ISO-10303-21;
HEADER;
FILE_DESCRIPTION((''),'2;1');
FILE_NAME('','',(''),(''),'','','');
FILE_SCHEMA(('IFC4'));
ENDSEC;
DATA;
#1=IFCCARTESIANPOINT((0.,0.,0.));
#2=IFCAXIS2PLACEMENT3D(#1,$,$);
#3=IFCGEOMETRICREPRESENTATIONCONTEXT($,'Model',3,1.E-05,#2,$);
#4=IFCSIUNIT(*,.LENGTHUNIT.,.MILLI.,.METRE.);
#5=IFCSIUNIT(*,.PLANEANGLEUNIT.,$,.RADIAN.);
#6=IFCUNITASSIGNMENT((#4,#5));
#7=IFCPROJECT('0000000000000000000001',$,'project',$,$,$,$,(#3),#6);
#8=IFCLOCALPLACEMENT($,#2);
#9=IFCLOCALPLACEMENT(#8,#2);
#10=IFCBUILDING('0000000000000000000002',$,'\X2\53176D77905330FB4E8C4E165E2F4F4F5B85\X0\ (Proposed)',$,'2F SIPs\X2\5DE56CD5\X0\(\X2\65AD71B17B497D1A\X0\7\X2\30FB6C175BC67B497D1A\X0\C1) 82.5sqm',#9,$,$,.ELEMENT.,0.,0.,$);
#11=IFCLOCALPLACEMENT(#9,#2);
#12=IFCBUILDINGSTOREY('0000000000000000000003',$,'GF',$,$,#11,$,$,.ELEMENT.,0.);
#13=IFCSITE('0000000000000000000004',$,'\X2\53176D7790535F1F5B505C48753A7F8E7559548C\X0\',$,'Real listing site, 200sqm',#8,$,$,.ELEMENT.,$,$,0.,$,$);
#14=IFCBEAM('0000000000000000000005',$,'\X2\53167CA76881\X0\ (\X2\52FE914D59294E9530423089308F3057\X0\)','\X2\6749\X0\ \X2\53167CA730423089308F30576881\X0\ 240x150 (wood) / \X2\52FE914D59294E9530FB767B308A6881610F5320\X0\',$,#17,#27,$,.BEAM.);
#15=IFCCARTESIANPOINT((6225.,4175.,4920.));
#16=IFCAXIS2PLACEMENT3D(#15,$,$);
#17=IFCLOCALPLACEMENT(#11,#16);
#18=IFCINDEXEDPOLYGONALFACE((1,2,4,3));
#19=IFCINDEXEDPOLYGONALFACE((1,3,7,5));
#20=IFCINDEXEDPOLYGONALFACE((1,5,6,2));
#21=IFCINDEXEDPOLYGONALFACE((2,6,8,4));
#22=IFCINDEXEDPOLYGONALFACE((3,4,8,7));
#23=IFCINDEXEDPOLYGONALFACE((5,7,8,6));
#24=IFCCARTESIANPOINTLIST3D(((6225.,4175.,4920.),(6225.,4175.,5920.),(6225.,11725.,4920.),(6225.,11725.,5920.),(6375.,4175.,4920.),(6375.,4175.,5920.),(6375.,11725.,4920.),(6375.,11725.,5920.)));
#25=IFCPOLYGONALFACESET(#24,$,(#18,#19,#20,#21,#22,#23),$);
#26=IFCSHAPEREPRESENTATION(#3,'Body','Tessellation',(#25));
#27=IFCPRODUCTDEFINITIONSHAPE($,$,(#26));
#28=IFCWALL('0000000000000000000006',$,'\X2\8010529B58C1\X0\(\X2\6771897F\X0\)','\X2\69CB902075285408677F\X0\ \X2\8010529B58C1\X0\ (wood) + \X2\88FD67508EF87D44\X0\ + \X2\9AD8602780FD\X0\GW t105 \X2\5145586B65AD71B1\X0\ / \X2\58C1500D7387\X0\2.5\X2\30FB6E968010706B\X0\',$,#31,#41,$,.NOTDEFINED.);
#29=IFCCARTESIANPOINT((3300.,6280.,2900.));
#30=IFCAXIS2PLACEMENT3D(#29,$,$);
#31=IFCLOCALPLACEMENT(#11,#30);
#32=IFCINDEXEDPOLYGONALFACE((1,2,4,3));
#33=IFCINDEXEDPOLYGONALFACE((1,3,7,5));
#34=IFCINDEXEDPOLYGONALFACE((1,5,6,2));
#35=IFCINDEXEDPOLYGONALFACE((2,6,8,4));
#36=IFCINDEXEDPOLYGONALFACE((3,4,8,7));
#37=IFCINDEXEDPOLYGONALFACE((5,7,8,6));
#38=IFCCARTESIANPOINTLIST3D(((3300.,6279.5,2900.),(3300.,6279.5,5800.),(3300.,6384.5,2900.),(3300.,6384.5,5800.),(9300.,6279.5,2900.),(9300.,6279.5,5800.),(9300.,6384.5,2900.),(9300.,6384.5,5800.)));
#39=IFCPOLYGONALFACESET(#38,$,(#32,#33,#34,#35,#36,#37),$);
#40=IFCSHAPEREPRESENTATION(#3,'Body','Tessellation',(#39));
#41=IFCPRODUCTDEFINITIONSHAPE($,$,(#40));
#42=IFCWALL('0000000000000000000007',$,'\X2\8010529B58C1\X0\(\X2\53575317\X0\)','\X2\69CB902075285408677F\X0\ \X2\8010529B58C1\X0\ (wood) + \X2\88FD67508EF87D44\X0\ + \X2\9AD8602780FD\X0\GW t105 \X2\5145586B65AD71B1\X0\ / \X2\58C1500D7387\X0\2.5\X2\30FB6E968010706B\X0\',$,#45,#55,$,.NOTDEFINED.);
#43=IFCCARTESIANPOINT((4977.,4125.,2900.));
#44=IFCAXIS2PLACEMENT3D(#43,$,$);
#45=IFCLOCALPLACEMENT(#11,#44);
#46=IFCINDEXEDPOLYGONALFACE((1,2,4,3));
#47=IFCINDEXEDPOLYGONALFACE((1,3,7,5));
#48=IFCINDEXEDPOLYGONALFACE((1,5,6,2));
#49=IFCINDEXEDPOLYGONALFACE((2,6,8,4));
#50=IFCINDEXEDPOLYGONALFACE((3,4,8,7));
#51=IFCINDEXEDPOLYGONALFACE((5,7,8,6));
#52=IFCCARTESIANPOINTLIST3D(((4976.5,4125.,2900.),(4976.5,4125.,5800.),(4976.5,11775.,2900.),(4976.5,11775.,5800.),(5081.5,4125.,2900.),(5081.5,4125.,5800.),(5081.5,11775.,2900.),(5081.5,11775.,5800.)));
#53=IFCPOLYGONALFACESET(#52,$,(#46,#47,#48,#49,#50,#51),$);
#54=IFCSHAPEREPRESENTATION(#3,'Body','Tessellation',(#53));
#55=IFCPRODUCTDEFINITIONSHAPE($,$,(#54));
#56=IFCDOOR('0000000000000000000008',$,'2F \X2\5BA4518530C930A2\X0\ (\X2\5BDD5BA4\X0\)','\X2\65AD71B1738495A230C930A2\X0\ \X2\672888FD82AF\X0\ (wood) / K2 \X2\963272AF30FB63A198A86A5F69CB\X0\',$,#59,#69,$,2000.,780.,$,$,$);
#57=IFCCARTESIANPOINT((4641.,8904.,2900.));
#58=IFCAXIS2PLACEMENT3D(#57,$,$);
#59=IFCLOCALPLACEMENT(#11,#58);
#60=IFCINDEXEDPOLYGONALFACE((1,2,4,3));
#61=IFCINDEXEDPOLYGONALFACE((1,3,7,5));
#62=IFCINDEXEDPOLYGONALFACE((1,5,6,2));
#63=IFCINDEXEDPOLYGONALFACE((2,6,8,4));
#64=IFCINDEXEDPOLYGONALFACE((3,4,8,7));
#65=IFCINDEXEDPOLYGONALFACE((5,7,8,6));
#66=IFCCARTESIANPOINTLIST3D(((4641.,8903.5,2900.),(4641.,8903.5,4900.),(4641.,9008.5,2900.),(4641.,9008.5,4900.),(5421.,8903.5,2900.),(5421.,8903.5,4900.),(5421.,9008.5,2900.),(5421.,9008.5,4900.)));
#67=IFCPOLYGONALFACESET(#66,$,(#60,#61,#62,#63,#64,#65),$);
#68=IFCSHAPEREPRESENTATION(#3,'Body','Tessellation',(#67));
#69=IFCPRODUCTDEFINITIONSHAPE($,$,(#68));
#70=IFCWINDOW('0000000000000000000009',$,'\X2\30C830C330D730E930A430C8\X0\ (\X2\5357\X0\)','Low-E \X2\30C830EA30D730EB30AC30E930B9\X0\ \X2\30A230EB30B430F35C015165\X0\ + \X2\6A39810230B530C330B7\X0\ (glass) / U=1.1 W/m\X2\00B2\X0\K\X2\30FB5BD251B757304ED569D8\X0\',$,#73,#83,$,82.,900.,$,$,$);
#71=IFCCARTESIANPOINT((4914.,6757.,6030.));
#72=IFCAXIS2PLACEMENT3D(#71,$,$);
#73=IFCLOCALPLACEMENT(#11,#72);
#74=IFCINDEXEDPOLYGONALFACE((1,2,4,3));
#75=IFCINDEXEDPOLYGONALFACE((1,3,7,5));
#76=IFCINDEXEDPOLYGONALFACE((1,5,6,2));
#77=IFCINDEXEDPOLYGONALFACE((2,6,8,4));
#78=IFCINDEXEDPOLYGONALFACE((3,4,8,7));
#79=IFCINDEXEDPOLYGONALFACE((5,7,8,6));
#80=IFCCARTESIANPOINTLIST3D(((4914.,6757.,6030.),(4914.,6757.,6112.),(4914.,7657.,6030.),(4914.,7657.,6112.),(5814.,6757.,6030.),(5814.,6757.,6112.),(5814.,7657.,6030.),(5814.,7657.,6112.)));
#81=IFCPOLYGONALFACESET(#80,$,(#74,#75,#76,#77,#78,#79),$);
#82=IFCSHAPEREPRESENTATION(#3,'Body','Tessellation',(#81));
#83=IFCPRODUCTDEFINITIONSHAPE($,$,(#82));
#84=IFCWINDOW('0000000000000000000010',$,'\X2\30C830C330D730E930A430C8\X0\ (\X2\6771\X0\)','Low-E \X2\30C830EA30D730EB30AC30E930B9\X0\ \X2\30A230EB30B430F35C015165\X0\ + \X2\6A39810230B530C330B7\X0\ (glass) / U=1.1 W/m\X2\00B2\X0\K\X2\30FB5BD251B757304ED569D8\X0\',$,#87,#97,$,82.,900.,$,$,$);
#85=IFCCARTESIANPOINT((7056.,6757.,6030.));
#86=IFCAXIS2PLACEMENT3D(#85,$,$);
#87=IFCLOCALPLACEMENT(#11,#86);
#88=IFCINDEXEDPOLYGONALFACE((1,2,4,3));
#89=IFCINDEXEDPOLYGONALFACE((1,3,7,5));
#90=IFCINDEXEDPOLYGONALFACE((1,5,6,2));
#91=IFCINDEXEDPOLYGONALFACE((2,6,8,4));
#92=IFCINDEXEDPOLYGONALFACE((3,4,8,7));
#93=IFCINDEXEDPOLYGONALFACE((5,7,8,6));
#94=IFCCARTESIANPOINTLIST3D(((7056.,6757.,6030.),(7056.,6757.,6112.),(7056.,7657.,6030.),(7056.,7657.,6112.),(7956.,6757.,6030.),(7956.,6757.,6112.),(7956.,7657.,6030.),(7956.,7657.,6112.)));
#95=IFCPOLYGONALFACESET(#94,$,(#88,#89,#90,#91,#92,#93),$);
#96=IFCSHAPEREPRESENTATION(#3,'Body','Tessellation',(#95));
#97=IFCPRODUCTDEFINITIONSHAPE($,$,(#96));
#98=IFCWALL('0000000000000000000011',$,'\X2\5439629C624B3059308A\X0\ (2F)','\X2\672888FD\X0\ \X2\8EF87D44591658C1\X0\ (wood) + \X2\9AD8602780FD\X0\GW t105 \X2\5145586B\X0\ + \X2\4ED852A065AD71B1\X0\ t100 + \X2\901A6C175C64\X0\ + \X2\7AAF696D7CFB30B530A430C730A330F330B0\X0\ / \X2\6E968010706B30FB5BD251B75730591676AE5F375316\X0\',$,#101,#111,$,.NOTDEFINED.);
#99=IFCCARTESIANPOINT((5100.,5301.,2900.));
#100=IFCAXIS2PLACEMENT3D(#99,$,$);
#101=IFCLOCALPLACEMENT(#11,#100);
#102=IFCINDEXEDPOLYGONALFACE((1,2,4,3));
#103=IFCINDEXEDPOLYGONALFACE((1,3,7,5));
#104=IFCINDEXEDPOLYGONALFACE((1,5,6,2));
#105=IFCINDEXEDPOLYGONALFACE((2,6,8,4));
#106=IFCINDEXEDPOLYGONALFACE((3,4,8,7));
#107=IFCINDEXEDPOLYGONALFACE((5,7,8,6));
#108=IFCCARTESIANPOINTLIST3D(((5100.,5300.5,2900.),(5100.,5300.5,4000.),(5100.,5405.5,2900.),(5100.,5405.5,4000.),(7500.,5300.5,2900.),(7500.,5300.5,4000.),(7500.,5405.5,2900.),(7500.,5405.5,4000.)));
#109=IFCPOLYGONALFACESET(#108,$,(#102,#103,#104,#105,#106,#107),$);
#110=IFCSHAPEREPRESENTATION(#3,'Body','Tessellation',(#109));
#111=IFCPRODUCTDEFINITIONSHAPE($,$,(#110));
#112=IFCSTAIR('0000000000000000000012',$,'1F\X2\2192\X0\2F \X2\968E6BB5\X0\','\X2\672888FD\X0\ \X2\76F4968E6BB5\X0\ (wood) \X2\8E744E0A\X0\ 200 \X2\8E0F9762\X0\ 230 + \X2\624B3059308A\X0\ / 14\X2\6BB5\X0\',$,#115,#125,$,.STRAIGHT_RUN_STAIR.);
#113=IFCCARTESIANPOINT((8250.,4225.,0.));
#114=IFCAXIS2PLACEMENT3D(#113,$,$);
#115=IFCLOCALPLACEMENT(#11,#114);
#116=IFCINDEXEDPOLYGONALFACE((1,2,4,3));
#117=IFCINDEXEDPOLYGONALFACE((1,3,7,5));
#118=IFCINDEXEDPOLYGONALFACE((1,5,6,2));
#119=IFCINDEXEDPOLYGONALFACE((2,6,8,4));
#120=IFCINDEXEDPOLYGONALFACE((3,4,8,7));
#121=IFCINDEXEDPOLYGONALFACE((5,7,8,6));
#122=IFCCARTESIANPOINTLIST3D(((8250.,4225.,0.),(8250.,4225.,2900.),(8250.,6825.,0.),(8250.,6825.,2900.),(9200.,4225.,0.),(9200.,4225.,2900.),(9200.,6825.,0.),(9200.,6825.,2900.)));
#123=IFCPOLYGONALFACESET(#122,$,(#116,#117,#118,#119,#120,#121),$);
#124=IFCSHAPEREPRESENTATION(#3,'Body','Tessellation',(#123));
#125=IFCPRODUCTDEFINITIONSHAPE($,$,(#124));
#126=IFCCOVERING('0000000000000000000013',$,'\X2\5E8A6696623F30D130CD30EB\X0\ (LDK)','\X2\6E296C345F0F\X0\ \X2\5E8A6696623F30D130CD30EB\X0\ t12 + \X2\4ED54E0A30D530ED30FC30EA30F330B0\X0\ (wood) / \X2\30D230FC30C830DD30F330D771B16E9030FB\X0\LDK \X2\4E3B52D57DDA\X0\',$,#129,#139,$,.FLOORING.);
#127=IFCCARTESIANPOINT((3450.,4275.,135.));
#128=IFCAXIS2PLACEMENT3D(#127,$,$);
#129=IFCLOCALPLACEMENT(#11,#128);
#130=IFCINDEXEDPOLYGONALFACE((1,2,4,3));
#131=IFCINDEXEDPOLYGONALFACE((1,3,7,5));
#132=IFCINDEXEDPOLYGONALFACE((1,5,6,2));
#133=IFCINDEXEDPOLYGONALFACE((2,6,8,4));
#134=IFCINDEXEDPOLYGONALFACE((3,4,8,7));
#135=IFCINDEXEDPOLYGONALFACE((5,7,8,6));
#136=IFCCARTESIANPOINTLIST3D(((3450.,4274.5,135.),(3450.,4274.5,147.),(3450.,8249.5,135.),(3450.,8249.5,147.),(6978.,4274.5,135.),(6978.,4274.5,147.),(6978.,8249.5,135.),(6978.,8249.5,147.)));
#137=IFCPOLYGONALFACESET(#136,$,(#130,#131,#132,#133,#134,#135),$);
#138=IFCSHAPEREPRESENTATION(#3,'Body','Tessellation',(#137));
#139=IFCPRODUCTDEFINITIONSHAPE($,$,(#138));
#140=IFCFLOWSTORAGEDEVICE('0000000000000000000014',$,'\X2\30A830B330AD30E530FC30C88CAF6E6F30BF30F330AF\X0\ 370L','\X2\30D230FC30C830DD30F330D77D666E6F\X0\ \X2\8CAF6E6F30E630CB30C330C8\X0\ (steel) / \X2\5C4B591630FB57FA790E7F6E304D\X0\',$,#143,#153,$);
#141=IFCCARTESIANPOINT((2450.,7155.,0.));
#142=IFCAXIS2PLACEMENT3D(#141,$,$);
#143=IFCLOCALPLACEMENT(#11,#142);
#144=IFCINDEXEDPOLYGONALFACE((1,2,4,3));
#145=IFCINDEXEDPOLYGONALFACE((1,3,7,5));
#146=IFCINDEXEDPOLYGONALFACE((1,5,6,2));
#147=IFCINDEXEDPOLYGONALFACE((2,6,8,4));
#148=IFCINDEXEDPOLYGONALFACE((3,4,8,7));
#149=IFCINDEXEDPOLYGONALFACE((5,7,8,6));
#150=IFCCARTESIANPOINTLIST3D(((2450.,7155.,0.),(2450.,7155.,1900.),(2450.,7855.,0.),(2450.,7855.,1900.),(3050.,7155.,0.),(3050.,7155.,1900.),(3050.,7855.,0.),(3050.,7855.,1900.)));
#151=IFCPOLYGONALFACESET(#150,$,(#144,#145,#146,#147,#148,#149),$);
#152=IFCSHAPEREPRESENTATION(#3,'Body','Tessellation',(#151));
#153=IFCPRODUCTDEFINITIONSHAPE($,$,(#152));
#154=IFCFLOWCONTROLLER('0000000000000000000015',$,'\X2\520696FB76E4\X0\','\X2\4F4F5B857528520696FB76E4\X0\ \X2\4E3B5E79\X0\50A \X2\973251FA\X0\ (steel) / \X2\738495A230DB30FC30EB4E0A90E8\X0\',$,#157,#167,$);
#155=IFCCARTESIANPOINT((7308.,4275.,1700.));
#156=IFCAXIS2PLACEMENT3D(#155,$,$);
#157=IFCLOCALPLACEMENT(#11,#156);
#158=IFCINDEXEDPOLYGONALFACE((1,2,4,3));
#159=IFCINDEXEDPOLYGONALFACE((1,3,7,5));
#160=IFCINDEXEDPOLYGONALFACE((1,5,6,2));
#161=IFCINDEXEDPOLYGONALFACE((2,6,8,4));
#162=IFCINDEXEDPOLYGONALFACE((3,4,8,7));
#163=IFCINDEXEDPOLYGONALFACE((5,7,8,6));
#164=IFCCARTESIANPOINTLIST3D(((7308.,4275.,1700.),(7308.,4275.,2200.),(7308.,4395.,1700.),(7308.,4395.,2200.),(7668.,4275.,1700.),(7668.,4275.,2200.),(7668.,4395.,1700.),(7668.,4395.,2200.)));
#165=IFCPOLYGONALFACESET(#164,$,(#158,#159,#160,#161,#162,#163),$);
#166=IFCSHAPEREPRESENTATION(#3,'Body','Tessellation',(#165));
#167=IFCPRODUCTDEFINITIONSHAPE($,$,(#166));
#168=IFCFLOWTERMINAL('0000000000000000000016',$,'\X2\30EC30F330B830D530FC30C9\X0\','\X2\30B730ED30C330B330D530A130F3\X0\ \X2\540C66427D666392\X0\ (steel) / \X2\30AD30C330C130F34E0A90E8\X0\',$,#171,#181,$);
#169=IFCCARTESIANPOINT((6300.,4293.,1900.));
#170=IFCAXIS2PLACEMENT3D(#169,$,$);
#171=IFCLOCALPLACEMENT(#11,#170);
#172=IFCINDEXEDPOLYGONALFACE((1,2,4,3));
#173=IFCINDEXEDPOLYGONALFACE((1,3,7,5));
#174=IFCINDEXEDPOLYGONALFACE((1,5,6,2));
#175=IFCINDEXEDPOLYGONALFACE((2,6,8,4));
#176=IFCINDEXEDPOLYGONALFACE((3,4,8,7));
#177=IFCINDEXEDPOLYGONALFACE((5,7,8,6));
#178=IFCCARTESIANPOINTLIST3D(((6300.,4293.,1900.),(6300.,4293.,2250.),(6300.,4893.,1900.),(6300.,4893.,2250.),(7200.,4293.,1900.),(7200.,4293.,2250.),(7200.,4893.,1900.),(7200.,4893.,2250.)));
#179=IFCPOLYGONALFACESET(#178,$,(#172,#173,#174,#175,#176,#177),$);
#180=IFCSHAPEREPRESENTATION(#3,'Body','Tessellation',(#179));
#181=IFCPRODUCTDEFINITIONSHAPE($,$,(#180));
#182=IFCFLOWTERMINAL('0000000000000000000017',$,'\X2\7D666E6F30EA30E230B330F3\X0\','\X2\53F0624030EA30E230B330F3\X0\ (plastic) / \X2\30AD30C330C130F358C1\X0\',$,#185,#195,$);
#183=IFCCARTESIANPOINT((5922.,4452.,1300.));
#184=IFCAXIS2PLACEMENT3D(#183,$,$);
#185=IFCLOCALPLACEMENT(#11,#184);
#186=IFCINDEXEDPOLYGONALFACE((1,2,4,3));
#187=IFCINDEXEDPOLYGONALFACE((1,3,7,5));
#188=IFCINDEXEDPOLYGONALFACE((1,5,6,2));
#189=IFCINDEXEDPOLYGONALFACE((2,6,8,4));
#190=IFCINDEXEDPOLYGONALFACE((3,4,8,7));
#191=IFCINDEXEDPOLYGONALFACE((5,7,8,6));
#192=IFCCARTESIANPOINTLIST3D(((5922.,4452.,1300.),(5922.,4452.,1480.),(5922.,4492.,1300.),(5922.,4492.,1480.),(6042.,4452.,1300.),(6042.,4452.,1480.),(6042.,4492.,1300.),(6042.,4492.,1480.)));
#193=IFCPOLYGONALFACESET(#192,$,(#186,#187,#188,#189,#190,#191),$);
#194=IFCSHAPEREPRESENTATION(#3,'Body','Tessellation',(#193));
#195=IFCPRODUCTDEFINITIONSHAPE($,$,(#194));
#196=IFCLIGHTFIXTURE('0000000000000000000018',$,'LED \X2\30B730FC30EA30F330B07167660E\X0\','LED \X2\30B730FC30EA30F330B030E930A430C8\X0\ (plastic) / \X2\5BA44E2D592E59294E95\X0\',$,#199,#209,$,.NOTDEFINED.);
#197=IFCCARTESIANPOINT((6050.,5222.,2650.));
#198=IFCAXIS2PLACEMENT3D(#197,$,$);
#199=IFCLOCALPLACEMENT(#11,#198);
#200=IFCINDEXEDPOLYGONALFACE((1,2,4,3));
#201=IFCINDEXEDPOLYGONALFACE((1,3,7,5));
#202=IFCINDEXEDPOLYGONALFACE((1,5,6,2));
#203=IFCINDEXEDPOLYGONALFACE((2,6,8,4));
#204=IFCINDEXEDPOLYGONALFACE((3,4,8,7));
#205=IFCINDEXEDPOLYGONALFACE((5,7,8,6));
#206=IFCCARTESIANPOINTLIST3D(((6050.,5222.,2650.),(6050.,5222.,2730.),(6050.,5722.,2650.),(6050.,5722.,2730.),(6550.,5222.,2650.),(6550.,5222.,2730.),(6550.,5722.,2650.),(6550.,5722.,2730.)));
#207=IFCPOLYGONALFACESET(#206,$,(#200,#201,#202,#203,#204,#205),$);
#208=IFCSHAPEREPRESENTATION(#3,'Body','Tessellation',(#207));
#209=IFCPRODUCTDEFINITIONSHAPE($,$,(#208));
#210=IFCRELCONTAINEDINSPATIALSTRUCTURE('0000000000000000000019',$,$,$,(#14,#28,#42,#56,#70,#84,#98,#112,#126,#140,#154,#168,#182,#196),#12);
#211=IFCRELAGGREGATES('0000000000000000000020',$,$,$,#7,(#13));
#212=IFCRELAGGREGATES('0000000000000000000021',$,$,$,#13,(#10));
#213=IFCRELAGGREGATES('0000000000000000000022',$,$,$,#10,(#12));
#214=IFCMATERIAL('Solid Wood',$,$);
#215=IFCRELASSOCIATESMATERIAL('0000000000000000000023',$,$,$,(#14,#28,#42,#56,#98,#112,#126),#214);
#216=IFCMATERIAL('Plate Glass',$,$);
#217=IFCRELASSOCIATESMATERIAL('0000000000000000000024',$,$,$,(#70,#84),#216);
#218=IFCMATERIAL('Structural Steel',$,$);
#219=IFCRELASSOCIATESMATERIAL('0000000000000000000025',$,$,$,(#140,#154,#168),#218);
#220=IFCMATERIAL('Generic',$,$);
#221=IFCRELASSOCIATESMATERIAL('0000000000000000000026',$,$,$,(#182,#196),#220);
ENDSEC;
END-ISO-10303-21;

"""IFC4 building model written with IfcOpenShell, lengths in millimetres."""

from ifc_helpers import new_model, si_unit, frame, frame_2d, origin, place, context, project, spatial, rectangle, extrude, material, element, fill, save


model = new_model("IFC4")

# Units and contexts
model_context = context("Model", 3, precision=1e-05, world=origin())
ifc_project = project(units=[si_unit("LENGTHUNIT", "METRE", prefix="MILLI"), si_unit("PLANEANGLEUNIT", "RADIAN")], contexts=[model_context])

# Site, building, storey
site_placement = place(None, origin())
site = spatial("IfcSite", under=ifc_project, at=site_placement, Name="北海道弟子屈町美留和", ObjectType="Real listing site, 200sqm", CompositionType="ELEMENT", RefElevation=0.0)
building_placement = place(site_placement, origin())
building = spatial("IfcBuilding", under=site, at=building_placement, Name="北海道・二世帯住宅 (Proposed)", ObjectType="2F SIPs工法(断熱等級7・気密等級C1) 82.5sqm", CompositionType="ELEMENT", ElevationOfRefHeight=0.0, ElevationOfTerrain=0.0)
storey_placement = place(building_placement, origin())
storey = spatial("IfcBuildingStorey", under=building, at=storey_placement, Name="GF", CompositionType="ELEMENT", Elevation=0.0)

# Shared definitions
ifc_material_1 = material(Name="Solid Wood")

# Beam
beam_placement = place(storey_placement, frame((6225.0, 4175.0, 4920.0)))
element("IfcBeam", 1, at=beam_placement, inside=storey, material=ifc_material_1, Name="化粧梁 (勾配天井あらわし)", Description="杉 化粧あらわし梁 240x150 (wood) / 勾配天井・登り梁意匠", PredefinedType="BEAM", context=model_context, shape_type="SweptSolid", body=[
    extrude(rectangle(XDim=150.0, YDim=7550.0, at=frame_2d((75.0, 3775.0))), frame((6225.0, 4175.0, 4920.0)), (0.0, 0.0, 1.0), 1000.0),
])

# Wall
wall_1_placement = place(storey_placement, frame((3300.0, 6280.0, 2900.0)))
element("IfcWall", 2, at=wall_1_placement, inside=storey, material=ifc_material_1, Name="耐力壁(東西)", Description="構造用合板 耐力壁 (wood) + 製材軸組 + 高性能GW t105 充填断熱 / 壁倍率2.5・準耐火", PredefinedType="NOTDEFINED", context=model_context, shape_type="SweptSolid", body=[
    extrude(rectangle(XDim=6000.0, YDim=105.0, at=frame_2d((3000.0, 52.0))), frame((3300.0, 6280.0, 2900.0)), (0.0, 0.0, 1.0), 2900.0),
])

# Wall, opening, door
wall_2_placement = place(storey_placement, frame((4977.0, 4125.0, 2900.0)))
wall_2 = element("IfcWall", 3, at=wall_2_placement, inside=storey, material=ifc_material_1, Name="耐力壁(南北)", Description="構造用合板 耐力壁 (wood) + 製材軸組 + 高性能GW t105 充填断熱 / 壁倍率2.5・準耐火", PredefinedType="NOTDEFINED", context=model_context, shape_type="SweptSolid", body=[
    extrude(rectangle(XDim=105.0, YDim=7650.0, at=frame_2d((52.0, 3825.0))), frame((4977.0, 4125.0, 2900.0)), (0.0, 0.0, 1.0), 2900.0),
])
opening_placement = place(storey_placement, frame((4641.0, 8904.0, 2900.0)))
opening = element("IfcOpeningElement", 4, at=opening_placement, cuts=wall_2, PredefinedType="NOTDEFINED", context=model_context, shape_type="SweptSolid", body=[
    extrude(rectangle(XDim=780.0, YDim=105.0, at=frame_2d((390.0, 52.0))), frame((4641.0, 8904.0, 2900.0)), (0.0, 0.0, 1.0), 2000.0),
])
door_placement = place(storey_placement, frame((4641.0, 8904.0, 2900.0)))
door = element("IfcDoor", 5, at=door_placement, inside=storey, material=ifc_material_1, Name="2F 室内ドア (寝室)", Description="断熱玄関ドア 木製芯 (wood) / K2 防犯・採風機構", OverallHeight=2000.0, OverallWidth=780.0, context=model_context, shape_type="SweptSolid", body=[
    extrude(rectangle(XDim=780.0, YDim=105.0, at=frame_2d((390.0, 52.0))), frame((4641.0, 8904.0, 2900.0)), (0.0, 0.0, 1.0), 2000.0),
])
fill(opening, door)

# Windows
ifc_material_2 = material(Name="Plate Glass")
window_1_placement = place(storey_placement, frame((4914.0, 6757.0, 6030.0)))
element("IfcWindow", 6, at=window_1_placement, inside=storey, material=ifc_material_2, Name="トップライト (南)", Description="Low-E トリプルガラス アルゴン封入 + 樹脂サッシ (glass) / U=1.1 W/m²K・寒冷地仕様", OverallHeight=82.0, OverallWidth=900.0, context=model_context, shape_type="SweptSolid", body=[
    extrude(rectangle(XDim=900.0, YDim=900.0, at=frame_2d((450.0, 450.0))), frame((4914.0, 6757.0, 6030.0)), (0.0, 0.0, 1.0), 82.0),
])
window_2_placement = place(storey_placement, frame((7056.0, 6757.0, 6030.0)))
element("IfcWindow", 7, at=window_2_placement, inside=storey, material=ifc_material_2, Name="トップライト (東)", Description="Low-E トリプルガラス アルゴン封入 + 樹脂サッシ (glass) / U=1.1 W/m²K・寒冷地仕様", OverallHeight=82.0, OverallWidth=900.0, context=model_context, shape_type="SweptSolid", body=[
    extrude(rectangle(XDim=900.0, YDim=900.0, at=frame_2d((450.0, 450.0))), frame((7056.0, 6757.0, 6030.0)), (0.0, 0.0, 1.0), 82.0),
])

# Wall
wall_3_placement = place(storey_placement, frame((5100.0, 5301.0, 2900.0)))
element("IfcWall", 8, at=wall_3_placement, inside=storey, material=ifc_material_1, Name="吹抜手すり (2F)", Description="木製 軸組外壁 (wood) + 高性能GW t105 充填 + 付加断熱 t100 + 通気層 + 窯業系サイディング / 準耐火・寒冷地外皮強化", PredefinedType="NOTDEFINED", context=model_context, shape_type="SweptSolid", body=[
    extrude(rectangle(XDim=2400.0, YDim=105.0, at=frame_2d((1200.0, 52.0))), frame((5100.0, 5301.0, 2900.0)), (0.0, 0.0, 1.0), 1100.0),
])

# Stair
stair_placement = place(storey_placement, frame((8250.0, 4225.0, 0.0)))
element("IfcStair", 9, at=stair_placement, inside=storey, material=ifc_material_1, Name="1F→2F 階段", Description="木製 直階段 (wood) 蹴上 200 踏面 230 + 手すり / 14段", PredefinedType="STRAIGHT_RUN_STAIR", context=model_context, shape_type="SweptSolid", body=[
    extrude(rectangle(XDim=950.0, YDim=2600.0, at=frame_2d((475.0, 1300.0))), frame((8250.0, 4225.0, 0.0)), (0.0, 0.0, 1.0), 2900.0),
])

# Covering
covering_placement = place(storey_placement, frame((3450.0, 4275.0, 135.0)))
element("IfcCovering", 10, at=covering_placement, inside=storey, material=ifc_material_1, Name="床暖房パネル (LDK)", Description="温水式 床暖房パネル t12 + 仕上フローリング (wood) / ヒートポンプ熱源・LDK 主動線", PredefinedType="FLOORING", context=model_context, shape_type="SweptSolid", body=[
    extrude(rectangle(XDim=3528.0, YDim=3975.0, at=frame_2d((1764.0, 1987.0))), frame((3450.0, 4275.0, 135.0)), (0.0, 0.0, 1.0), 12.0),
])

# Flow storage device
ifc_material_3 = material(Name="Structural Steel")
flow_storage_device_1_placement = place(storey_placement, frame((2450.0, 7155.0, 0.0)))
element("IfcFlowStorageDevice", 11, at=flow_storage_device_1_placement, inside=storey, material=ifc_material_3, Name="エコキュート貯湯タンク 370L", Description="ヒートポンプ給湯 貯湯ユニット (steel) / 屋外・基礎置き", context=model_context, shape_type="SweptSolid", body=[
    extrude(rectangle(XDim=600.0, YDim=700.0, at=frame_2d((300.0, 350.0))), frame((2450.0, 7155.0, 0.0)), (0.0, 0.0, 1.0), 1900.0),
])

# Flow controller
flow_controller_placement = place(storey_placement, frame((7308.0, 4275.0, 1700.0)))
element("IfcFlowController", 12, at=flow_controller_placement, inside=storey, material=ifc_material_3, Name="分電盤", Description="住宅用分電盤 主幹50A 露出 (steel) / 玄関ホール上部", context=model_context, shape_type="SweptSolid", body=[
    extrude(rectangle(XDim=360.0, YDim=120.0, at=frame_2d((180.0, 60.0))), frame((7308.0, 4275.0, 1700.0)), (0.0, 0.0, 1.0), 500.0),
])

# Flow terminals
flow_terminal_1_placement = place(storey_placement, frame((6300.0, 4293.0, 1900.0)))
element("IfcFlowTerminal", 13, at=flow_terminal_1_placement, inside=storey, material=ifc_material_3, Name="レンジフード", Description="シロッコファン 同時給排 (steel) / キッチン上部", context=model_context, shape_type="SweptSolid", body=[
    extrude(rectangle(XDim=900.0, YDim=600.0, at=frame_2d((450.0, 300.0))), frame((6300.0, 4293.0, 1900.0)), (0.0, 0.0, 1.0), 350.0),
])
ifc_material_4 = material(Name="Generic")
flow_terminal_2_placement = place(storey_placement, frame((5922.0, 4452.0, 1300.0)))
element("IfcFlowTerminal", 14, at=flow_terminal_2_placement, inside=storey, material=ifc_material_4, Name="給湯リモコン", Description="台所リモコン (plastic) / キッチン壁", context=model_context, shape_type="SweptSolid", body=[
    extrude(rectangle(XDim=120.0, YDim=40.0, at=frame_2d((60.0, 20.0))), frame((5922.0, 4452.0, 1300.0)), (0.0, 0.0, 1.0), 180.0),
])

# Light fixture
light_fixture_1_placement = place(storey_placement, frame((6050.0, 5222.0, 2650.0)))
element("IfcLightFixture", 15, at=light_fixture_1_placement, inside=storey, material=ifc_material_4, Name="LED シーリング照明", Description="LED シーリングライト (plastic) / 室中央天井", PredefinedType="NOTDEFINED", context=model_context, shape_type="SweptSolid", body=[
    extrude(rectangle(XDim=500.0, YDim=500.0, at=frame_2d((250.0, 250.0))), frame((6050.0, 5222.0, 2650.0)), (0.0, 0.0, 1.0), 80.0),
])

save(model, "model.ifc")
